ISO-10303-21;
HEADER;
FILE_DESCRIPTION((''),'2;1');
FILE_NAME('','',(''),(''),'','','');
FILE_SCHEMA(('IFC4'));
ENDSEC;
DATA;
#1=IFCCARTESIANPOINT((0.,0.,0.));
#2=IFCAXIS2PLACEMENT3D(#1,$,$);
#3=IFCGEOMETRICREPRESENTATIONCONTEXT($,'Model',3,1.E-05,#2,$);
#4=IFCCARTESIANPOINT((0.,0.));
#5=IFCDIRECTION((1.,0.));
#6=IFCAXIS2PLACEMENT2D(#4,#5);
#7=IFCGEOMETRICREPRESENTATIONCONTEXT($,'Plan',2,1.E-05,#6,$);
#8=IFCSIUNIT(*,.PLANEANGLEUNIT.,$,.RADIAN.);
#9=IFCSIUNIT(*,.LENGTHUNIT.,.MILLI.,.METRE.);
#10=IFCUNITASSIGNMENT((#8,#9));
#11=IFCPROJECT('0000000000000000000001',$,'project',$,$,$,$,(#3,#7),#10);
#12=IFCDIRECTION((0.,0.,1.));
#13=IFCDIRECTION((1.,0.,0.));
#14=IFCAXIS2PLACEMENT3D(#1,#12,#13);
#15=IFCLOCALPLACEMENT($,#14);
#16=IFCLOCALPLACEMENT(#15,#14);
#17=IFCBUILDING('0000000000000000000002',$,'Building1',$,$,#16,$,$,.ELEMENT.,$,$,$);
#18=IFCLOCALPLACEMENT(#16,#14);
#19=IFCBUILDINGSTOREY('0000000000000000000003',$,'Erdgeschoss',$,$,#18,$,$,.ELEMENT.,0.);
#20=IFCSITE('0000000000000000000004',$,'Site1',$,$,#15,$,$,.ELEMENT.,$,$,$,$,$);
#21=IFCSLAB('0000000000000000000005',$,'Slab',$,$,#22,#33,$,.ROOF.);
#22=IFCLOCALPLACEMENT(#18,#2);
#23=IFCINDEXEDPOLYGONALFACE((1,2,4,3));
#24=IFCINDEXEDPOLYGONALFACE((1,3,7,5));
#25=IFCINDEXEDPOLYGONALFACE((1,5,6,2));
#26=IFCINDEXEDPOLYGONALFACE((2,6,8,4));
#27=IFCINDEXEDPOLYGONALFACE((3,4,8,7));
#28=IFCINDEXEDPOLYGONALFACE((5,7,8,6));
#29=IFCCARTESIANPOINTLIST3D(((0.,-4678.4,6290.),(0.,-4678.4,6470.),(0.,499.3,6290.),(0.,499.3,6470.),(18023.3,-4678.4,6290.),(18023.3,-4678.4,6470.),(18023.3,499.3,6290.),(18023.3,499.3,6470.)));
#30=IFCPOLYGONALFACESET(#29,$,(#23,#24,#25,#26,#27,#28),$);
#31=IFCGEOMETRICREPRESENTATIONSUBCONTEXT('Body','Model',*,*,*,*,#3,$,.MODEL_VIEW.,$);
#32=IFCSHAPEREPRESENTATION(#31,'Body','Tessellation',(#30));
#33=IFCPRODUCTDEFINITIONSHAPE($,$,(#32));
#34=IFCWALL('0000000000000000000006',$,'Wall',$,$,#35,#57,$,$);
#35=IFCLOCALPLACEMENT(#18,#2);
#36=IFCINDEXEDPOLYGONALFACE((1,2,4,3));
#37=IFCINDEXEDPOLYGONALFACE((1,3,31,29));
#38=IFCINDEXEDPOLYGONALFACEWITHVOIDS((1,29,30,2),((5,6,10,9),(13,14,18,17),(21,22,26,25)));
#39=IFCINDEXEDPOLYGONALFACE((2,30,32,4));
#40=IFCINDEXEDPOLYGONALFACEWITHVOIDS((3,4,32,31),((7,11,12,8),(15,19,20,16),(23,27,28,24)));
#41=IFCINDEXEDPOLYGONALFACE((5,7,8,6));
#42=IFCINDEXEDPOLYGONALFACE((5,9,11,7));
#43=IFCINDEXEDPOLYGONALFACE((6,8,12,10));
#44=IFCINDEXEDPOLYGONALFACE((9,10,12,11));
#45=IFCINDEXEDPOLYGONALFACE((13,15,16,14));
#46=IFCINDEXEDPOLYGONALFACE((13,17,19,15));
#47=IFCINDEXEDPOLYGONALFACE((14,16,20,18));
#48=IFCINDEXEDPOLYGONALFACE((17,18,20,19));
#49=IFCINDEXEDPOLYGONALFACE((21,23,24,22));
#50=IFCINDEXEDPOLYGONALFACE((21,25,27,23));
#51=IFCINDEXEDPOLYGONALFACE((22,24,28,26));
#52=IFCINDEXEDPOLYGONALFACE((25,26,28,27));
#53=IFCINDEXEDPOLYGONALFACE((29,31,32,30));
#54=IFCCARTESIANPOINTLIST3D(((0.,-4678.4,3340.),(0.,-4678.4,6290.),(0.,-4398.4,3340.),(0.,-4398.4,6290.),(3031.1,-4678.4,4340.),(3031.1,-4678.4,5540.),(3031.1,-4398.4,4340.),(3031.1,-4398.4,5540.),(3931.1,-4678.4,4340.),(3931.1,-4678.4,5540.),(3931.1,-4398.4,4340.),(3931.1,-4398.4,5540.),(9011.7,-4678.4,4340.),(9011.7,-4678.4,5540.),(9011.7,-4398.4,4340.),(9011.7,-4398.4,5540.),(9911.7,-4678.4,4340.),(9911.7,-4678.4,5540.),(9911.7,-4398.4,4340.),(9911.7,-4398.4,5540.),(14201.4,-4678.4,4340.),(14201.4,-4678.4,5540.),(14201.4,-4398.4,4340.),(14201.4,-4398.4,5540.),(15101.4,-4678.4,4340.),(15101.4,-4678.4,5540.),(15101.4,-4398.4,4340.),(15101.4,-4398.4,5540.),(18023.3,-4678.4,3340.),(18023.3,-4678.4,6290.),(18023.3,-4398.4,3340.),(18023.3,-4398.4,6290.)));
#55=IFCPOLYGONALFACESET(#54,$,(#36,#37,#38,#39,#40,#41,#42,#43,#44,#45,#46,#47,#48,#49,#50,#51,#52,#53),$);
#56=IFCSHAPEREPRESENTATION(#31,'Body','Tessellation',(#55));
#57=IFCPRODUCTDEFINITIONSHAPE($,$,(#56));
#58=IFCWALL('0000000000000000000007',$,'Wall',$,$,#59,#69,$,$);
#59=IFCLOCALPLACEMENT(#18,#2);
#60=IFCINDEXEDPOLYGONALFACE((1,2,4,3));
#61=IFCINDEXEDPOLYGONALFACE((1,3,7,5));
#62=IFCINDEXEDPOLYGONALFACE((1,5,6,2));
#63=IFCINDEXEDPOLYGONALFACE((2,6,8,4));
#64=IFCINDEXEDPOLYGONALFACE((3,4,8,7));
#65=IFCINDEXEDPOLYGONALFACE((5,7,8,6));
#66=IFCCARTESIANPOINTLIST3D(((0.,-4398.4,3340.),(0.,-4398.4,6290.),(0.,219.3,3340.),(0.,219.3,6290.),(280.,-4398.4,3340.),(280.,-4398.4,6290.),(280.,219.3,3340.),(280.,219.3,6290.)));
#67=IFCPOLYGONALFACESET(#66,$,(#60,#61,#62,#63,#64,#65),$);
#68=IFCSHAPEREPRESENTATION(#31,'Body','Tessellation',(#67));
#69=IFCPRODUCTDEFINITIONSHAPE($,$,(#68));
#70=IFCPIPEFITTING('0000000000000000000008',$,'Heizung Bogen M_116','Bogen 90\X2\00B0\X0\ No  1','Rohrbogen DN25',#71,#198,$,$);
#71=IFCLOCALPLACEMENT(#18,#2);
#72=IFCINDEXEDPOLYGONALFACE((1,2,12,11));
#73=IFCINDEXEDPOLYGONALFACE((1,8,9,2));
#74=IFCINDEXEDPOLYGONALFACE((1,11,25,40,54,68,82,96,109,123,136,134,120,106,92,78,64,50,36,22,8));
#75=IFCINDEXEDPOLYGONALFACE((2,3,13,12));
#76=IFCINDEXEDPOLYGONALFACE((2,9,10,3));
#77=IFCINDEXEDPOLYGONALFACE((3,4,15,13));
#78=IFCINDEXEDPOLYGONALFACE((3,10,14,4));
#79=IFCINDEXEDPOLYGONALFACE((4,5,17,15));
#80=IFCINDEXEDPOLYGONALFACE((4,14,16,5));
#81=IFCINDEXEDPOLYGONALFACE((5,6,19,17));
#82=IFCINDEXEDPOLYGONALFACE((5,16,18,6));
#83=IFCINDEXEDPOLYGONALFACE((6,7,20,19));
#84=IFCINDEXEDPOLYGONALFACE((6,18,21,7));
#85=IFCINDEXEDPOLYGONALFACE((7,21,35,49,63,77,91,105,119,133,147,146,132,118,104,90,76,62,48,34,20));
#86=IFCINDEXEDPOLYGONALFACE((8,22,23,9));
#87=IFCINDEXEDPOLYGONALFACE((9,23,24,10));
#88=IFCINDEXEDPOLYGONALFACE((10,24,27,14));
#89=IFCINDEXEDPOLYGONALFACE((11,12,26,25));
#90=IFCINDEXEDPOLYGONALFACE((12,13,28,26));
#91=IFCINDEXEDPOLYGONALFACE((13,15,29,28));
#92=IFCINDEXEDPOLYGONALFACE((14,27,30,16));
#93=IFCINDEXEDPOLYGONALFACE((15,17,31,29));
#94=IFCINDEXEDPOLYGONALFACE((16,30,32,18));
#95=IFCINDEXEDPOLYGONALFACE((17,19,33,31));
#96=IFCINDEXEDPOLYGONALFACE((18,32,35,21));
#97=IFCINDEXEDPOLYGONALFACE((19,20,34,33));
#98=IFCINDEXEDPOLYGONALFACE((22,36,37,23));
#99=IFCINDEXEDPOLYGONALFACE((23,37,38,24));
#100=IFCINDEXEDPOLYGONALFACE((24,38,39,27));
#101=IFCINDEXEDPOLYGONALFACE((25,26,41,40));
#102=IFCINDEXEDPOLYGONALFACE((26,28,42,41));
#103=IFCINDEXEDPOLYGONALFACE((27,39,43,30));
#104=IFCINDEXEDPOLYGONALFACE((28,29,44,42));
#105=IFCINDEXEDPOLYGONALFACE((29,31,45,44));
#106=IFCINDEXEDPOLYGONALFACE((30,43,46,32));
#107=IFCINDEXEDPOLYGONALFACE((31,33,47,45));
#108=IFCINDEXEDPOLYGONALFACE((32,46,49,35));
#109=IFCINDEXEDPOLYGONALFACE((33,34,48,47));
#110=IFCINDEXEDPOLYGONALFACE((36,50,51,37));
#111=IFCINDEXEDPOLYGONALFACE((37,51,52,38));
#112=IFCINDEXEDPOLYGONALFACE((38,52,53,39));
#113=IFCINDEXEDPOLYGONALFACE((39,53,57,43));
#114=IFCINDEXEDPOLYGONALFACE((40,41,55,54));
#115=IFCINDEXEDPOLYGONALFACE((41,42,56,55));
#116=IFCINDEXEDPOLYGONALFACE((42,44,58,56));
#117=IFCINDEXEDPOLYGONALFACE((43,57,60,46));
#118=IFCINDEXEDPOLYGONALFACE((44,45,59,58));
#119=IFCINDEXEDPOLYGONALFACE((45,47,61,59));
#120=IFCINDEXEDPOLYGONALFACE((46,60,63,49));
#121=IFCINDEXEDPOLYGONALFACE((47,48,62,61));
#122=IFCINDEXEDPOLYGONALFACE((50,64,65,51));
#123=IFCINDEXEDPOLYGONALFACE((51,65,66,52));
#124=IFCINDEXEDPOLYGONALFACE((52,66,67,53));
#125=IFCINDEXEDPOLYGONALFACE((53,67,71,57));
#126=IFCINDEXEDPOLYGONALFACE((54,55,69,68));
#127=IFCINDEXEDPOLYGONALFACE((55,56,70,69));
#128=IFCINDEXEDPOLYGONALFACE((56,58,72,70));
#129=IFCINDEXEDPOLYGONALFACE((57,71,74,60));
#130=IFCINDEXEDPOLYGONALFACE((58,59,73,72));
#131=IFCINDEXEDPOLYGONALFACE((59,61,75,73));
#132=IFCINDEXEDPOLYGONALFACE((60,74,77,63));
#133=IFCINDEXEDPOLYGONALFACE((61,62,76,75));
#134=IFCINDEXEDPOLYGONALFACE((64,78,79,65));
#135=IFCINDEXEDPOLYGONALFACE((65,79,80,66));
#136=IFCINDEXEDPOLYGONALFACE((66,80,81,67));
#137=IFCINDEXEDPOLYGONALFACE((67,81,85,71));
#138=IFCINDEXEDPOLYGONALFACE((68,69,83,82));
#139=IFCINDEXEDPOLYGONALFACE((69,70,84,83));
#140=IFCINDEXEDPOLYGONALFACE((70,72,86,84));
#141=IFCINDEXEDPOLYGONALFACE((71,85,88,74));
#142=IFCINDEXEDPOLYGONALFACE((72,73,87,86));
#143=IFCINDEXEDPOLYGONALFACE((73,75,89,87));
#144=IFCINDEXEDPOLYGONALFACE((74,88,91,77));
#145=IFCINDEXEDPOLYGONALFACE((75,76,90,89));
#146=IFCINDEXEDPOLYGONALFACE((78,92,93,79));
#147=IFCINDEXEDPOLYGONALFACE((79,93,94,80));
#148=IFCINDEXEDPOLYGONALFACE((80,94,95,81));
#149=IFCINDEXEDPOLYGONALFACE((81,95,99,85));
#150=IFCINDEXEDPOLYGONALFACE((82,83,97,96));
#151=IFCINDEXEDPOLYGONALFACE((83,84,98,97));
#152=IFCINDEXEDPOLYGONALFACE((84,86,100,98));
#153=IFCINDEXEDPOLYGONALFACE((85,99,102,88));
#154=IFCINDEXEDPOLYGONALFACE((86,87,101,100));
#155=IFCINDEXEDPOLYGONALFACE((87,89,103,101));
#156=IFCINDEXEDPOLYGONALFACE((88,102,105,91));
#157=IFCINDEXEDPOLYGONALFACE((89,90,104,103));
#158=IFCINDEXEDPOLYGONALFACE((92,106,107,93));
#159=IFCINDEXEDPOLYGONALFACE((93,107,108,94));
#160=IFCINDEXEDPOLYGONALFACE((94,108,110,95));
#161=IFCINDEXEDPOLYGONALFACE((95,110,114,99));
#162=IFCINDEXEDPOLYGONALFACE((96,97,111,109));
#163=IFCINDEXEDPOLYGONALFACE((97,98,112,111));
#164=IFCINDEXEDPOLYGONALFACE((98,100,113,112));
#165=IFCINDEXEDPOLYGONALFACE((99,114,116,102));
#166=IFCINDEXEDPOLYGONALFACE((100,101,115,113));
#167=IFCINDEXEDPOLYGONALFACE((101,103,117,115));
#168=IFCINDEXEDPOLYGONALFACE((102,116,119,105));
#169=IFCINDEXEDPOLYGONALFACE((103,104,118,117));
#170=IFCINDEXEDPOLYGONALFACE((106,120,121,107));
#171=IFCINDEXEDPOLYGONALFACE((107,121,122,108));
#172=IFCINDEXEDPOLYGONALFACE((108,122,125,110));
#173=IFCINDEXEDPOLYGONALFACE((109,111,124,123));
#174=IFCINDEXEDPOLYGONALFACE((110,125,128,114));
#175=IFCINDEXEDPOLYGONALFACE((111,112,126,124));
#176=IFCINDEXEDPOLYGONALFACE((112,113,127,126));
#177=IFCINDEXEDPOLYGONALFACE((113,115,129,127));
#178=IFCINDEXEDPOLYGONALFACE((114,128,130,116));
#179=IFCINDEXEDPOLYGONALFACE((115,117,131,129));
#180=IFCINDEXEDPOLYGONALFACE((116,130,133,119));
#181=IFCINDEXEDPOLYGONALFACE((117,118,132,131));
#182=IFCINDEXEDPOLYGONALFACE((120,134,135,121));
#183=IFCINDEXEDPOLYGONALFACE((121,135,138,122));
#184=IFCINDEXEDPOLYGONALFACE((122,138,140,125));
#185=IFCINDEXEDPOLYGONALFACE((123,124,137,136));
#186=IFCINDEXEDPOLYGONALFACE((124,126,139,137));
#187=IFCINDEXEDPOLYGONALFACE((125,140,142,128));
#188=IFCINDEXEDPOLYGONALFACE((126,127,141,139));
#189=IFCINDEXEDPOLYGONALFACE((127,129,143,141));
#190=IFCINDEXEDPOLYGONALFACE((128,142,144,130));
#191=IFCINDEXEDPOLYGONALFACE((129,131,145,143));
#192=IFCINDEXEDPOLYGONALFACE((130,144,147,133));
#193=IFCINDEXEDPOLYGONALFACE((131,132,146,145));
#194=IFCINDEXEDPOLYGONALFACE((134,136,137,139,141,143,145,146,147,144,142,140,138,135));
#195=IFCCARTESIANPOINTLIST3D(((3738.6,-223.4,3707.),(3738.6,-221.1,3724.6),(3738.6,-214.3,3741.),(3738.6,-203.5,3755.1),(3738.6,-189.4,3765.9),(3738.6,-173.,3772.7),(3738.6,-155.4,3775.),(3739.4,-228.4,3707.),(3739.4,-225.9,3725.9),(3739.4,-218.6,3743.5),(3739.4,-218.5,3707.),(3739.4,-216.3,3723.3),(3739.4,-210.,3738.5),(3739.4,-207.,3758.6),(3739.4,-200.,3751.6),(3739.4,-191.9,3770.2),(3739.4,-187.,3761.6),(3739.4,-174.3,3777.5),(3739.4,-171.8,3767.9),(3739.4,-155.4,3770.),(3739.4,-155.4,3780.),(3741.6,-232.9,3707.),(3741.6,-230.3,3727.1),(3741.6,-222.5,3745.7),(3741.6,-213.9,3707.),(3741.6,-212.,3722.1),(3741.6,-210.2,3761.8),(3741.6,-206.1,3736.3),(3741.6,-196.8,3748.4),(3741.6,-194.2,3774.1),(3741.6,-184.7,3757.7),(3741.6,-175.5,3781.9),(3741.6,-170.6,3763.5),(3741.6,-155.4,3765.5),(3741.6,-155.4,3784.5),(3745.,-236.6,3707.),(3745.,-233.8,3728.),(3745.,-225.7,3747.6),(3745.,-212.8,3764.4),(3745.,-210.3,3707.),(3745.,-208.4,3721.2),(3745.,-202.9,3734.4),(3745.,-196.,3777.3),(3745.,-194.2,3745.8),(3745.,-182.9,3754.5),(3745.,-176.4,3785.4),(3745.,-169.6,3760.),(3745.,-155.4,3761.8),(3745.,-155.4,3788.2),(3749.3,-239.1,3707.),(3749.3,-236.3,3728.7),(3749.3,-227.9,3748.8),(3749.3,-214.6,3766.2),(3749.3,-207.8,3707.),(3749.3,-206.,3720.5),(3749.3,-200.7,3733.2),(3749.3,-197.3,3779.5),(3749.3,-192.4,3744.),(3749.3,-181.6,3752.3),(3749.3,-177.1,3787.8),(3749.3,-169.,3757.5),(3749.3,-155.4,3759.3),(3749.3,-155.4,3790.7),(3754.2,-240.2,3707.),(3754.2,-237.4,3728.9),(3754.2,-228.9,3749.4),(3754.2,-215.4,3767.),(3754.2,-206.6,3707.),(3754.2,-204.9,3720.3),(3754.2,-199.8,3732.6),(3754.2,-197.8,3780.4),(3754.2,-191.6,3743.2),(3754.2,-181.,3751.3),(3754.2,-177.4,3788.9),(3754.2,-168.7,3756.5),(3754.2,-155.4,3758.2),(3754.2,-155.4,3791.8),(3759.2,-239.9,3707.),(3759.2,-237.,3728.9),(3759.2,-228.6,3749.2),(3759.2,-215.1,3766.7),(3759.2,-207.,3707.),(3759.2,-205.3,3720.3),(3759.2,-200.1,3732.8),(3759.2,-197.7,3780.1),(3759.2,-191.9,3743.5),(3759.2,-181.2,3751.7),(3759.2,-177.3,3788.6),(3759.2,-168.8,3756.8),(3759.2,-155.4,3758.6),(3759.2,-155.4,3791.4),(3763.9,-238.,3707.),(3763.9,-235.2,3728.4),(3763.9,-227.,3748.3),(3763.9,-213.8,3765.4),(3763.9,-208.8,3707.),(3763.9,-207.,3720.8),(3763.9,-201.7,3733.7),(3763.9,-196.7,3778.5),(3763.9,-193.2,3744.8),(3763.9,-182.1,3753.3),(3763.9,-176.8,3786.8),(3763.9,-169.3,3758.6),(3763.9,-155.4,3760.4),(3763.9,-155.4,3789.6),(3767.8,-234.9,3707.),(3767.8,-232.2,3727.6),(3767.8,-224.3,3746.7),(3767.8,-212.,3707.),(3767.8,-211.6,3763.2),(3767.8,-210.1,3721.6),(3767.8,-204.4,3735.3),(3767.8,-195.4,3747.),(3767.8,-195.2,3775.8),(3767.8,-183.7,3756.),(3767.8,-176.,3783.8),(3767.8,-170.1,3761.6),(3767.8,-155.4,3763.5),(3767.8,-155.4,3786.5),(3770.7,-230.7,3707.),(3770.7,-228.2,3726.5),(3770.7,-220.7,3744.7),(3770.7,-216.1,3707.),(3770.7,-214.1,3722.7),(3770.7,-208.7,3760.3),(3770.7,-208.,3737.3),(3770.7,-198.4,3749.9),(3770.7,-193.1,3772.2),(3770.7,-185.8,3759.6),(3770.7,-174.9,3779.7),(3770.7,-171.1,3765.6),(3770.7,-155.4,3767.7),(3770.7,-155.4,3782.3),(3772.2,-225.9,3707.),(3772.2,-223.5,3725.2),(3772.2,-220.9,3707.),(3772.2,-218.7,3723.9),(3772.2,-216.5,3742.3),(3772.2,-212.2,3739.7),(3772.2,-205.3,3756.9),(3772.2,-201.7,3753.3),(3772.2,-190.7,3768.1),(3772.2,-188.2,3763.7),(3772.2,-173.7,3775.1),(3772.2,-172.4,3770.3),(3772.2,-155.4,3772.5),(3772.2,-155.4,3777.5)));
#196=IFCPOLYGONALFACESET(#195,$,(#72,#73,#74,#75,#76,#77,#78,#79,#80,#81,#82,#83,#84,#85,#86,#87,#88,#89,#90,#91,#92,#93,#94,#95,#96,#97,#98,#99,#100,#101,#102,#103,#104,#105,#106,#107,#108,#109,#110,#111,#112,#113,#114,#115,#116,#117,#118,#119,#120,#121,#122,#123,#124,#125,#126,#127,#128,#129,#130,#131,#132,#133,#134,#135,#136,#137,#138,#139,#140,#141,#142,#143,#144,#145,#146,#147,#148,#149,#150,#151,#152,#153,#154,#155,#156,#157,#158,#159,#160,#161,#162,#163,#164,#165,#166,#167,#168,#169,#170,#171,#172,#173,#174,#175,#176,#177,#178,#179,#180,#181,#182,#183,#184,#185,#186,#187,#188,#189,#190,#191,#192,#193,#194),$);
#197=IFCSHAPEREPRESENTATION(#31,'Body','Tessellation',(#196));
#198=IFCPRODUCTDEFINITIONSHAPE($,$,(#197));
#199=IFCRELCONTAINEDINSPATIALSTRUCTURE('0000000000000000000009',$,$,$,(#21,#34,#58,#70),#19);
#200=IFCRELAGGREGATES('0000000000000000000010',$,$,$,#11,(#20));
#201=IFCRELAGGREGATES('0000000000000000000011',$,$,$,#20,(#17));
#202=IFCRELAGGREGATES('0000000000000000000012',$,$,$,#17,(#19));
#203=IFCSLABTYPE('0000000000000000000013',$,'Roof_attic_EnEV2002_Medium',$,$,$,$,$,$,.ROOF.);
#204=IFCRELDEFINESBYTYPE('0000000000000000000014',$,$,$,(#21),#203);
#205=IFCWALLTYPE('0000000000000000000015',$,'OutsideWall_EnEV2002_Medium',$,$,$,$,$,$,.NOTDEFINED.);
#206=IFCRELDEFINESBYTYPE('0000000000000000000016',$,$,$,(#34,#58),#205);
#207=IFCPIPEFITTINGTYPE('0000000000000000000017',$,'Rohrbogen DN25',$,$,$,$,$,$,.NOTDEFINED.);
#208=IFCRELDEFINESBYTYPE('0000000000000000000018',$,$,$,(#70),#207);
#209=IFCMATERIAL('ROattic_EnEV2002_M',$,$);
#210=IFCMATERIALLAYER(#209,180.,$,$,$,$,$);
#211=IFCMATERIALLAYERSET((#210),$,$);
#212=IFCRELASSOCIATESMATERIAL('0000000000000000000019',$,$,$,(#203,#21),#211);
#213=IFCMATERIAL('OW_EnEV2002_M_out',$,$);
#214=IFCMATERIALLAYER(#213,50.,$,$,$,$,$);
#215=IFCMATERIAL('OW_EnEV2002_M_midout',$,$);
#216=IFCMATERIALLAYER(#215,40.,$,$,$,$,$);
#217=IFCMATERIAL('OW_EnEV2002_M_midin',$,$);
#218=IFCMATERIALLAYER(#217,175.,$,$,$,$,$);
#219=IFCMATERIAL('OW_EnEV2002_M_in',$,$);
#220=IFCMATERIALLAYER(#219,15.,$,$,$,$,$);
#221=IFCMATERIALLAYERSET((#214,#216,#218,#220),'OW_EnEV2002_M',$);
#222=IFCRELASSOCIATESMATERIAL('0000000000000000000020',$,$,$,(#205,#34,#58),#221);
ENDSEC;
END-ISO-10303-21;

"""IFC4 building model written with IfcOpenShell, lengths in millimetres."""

from ifc_helpers import new_model, entity, si_unit, frame, origin, origin_with_axes, origin_2d_with_axis, place, context, subcontext, project, spatial, line, indexed_curve, outline, extrude, source, transform, mapped, material, layer, layer_set, layer_usage, type_object, element, save


model = new_model("IFC4")

# Units and contexts
model_context = context("Model", 3, precision=1e-05, world=origin())
plan_context = context("Plan", 2, precision=1e-05, world=origin_2d_with_axis())
body_context = subcontext(model_context, "Body", "Model", "MODEL_VIEW")
ifc_project = project(units=[si_unit("PLANEANGLEUNIT", "RADIAN"), si_unit("LENGTHUNIT", "METRE", prefix="MILLI")], contexts=[model_context, plan_context])

# Site, building, storey
site_placement = place(None, origin_with_axes())
site = spatial("IfcSite", under=ifc_project, at=site_placement, Name="Site1", CompositionType="ELEMENT")
building_placement = place(site_placement, origin_with_axes())
building = spatial("IfcBuilding", under=site, at=building_placement, Name="Building1", CompositionType="ELEMENT")
storey_placement = place(building_placement, origin_with_axes())
storey = spatial("IfcBuildingStorey", under=building, at=storey_placement, Name="Erdgeschoss", CompositionType="ELEMENT", Elevation=0.0)

# Slab
ifc_material_1 = material(Name="ROattic_EnEV2002_M")
ifc_layer_1 = layer(ifc_material_1, 180.0)
ifc_layer_set_1 = layer_set([ifc_layer_1])
ifc_layer_usage_1 = layer_usage(ifc_layer_set_1, "AXIS3", "POSITIVE", 0.0)
slab_type = type_object("IfcSlabType", Name="Roof_attic_EnEV2002_Medium", PredefinedType="ROOF", material=ifc_layer_set_1)
slab_placement = place(storey_placement, frame((0.0, -4678.4, 6290.0), z_axis=(0.0, 0.0, 1.0), x_axis=(1.0, 0.0, 0.0)))
element("IfcSlab", 1, at=slab_placement, inside=storey, type_object=slab_type, material=ifc_layer_usage_1, Name="Slab", PredefinedType="ROOF", context=body_context, shape_type="SweptSolid", body=[
    extrude(outline(indexed_curve([(0.0, 0.0), (18023.3, 0.0), (18023.3, 5177.6), (0.0, 5177.6)], segments=[line(4, 1), line(1, 2), line(2, 3), line(3, 4)], self_intersect=False)), None, (0.0, 0.0, 1.0), 180.0),
])

# Wall, openings
ifc_material_2 = material(Name="OW_EnEV2002_M_out")
ifc_layer_2 = layer(ifc_material_2, 50.0)
ifc_material_3 = material(Name="OW_EnEV2002_M_midout")
ifc_layer_3 = layer(ifc_material_3, 40.0)
ifc_material_4 = material(Name="OW_EnEV2002_M_midin")
ifc_layer_4 = layer(ifc_material_4, 175.0)
ifc_material_5 = material(Name="OW_EnEV2002_M_in")
ifc_layer_5 = layer(ifc_material_5, 15.0)
ifc_layer_set_2 = layer_set([ifc_layer_2, ifc_layer_3, ifc_layer_4, ifc_layer_5], Name="OW_EnEV2002_M")
ifc_layer_usage_2 = layer_usage(ifc_layer_set_2, "AXIS2", "POSITIVE", 0.0)
wall_type = type_object("IfcWallType", Name="OutsideWall_EnEV2002_Medium", PredefinedType="NOTDEFINED", material=ifc_layer_set_2)
wall_1_placement = place(storey_placement, frame((0.0, -4678.4, 3340.0), z_axis=(0.0, 0.0, 1.0), x_axis=(1.0, 0.0, 0.0)))
wall_1 = element("IfcWall", 2, at=wall_1_placement, inside=storey, type_object=wall_type, material=ifc_layer_usage_2, Name="Wall", context=body_context, shape_type="SweptSolid", body=[
    extrude(outline(indexed_curve([(0.0, 0.0), (0.0, 280.0), (18023.3, 280.0), (18023.3, 0.0), (0.0, 0.0)], self_intersect=False)), origin_with_axes(), (0.0, 0.0, 1.0), 2950.0),
])
shared_shape_1 = source(origin_with_axes(), body_context, "Body", "SweptSolid", [
    extrude(outline(indexed_curve([(0.0, 0.0), (900.0, 0.0), (900.0, 1200.0), (0.0, 1200.0)], segments=[line(1, 2, 3, 4, 1)])), frame((0.0, -600.0, 0.0), z_axis=(0.0, -1.0, 0.0), x_axis=(1.0, 0.0, 0.0)), (0.0, 0.0, -1.0), 1200.0),
])
opening_1_placement = place(wall_1_placement, frame((3031.1, 0.0, 1000.0), z_axis=(0.0, 0.0, 1.0), x_axis=(1.0, 0.0, 0.0)))
element("IfcOpeningElement", 3, at=opening_1_placement, cuts=wall_1, PredefinedType="OPENING", context=body_context, shape_type="MappedRepresentation", body=[
    mapped(shared_shape_1, transform((0.0, 0.0, 0.0), x_axis=(1.0, 0.0, 0.0), y_axis=(0.0, 1.0, 0.0), z_axis=(0.0, 0.0, 1.0), scale=1.0)),
])
opening_2_placement = place(wall_1_placement, frame((9011.7, 0.0, 1000.0), z_axis=(0.0, 0.0, 1.0), x_axis=(1.0, 0.0, 0.0)))
element("IfcOpeningElement", 4, at=opening_2_placement, cuts=wall_1, PredefinedType="OPENING", context=body_context, shape_type="MappedRepresentation", body=[
    mapped(shared_shape_1, transform((0.0, 0.0, 0.0), x_axis=(1.0, 0.0, 0.0), y_axis=(0.0, 1.0, 0.0), z_axis=(0.0, 0.0, 1.0), scale=1.0)),
])
opening_3_placement = place(wall_1_placement, frame((14201.4, 0.0, 1000.0), z_axis=(0.0, 0.0, 1.0), x_axis=(1.0, 0.0, 0.0)))
element("IfcOpeningElement", 5, at=opening_3_placement, cuts=wall_1, PredefinedType="OPENING", context=body_context, shape_type="MappedRepresentation", body=[
    mapped(shared_shape_1, transform((0.0, 0.0, 0.0), x_axis=(1.0, 0.0, 0.0), y_axis=(0.0, 1.0, 0.0), z_axis=(0.0, 0.0, 1.0), scale=1.0)),
])

# Wall
ifc_layer_usage_3 = layer_usage(ifc_layer_set_2, "AXIS2", "POSITIVE", 0.0)
wall_2_placement = place(storey_placement, frame((0.0, 219.3, 3340.0), z_axis=(0.0, 0.0, 1.0), x_axis=(-0.000001, -1.0, 0.0)))
element("IfcWall", 6, at=wall_2_placement, inside=storey, type_object=wall_type, material=ifc_layer_usage_3, Name="Wall", context=body_context, shape_type="SweptSolid", body=[
    extrude(outline(indexed_curve([(0.0, 0.0), (0.0, 280.0), (4617.6, 280.0), (4617.6, 0.0), (0.0, 0.0)], self_intersect=False)), origin_with_axes(), (0.0, 0.0, 1.0), 2950.0),
])

# Pipe fitting
pipe_fitting_type_1 = type_object("IfcPipeFittingType", Name="Rohrbogen DN25", PredefinedType="NOTDEFINED")
shared_shape_2 = source(origin_with_axes(), body_context, "Body", "SolidModel", [
    entity("IfcRevolvedAreaSolid", entity("IfcCircleProfileDef", "AREA", None, entity("IfcAxis2Placement2D", entity("IfcCartesianPoint", [0.0, 0.0]), entity("IfcDirection", [1.0, 0.0])), 16.9), entity("IfcAxis2Placement3D", entity("IfcCartesianPoint", [-42.4, 0.0, 25.6]), entity("IfcDirection", [1.0, 0.0, 0.0]), entity("IfcDirection", [0.0, -1.0, 0.0])), entity("IfcAxis1Placement", entity("IfcCartesianPoint", [0.0, 68.0, 0.0]), entity("IfcDirection", [-1.0, 0.0, 0.0])), 1.570796),
])
for number, where, z_axis, x_axis, name in (
    (7, (3755.5, -197.9, 3749.4), (0.0, 0.0, 1.0), (1.0, 0.0, 0.0), "Heizung Bogen M_116"),
):
    element("IfcPipeFitting", number, at=place(storey_placement, frame(where, z_axis=z_axis, x_axis=x_axis)), inside=storey, type_object=pipe_fitting_type_1, Name=name, Description="Bogen 90° No  1", ObjectType="Rohrbogen DN25", context=body_context, shape_type="MappedRepresentation", body=[
        mapped(shared_shape_2, transform((0.0, 0.0, 0.0), x_axis=(0.0, -1.0, 0.0), y_axis=(1.0, 0.0, 0.0), z_axis=(0.0, 0.0, 1.0), scale=1.0)),
    ])

save(model, "model.ifc")
